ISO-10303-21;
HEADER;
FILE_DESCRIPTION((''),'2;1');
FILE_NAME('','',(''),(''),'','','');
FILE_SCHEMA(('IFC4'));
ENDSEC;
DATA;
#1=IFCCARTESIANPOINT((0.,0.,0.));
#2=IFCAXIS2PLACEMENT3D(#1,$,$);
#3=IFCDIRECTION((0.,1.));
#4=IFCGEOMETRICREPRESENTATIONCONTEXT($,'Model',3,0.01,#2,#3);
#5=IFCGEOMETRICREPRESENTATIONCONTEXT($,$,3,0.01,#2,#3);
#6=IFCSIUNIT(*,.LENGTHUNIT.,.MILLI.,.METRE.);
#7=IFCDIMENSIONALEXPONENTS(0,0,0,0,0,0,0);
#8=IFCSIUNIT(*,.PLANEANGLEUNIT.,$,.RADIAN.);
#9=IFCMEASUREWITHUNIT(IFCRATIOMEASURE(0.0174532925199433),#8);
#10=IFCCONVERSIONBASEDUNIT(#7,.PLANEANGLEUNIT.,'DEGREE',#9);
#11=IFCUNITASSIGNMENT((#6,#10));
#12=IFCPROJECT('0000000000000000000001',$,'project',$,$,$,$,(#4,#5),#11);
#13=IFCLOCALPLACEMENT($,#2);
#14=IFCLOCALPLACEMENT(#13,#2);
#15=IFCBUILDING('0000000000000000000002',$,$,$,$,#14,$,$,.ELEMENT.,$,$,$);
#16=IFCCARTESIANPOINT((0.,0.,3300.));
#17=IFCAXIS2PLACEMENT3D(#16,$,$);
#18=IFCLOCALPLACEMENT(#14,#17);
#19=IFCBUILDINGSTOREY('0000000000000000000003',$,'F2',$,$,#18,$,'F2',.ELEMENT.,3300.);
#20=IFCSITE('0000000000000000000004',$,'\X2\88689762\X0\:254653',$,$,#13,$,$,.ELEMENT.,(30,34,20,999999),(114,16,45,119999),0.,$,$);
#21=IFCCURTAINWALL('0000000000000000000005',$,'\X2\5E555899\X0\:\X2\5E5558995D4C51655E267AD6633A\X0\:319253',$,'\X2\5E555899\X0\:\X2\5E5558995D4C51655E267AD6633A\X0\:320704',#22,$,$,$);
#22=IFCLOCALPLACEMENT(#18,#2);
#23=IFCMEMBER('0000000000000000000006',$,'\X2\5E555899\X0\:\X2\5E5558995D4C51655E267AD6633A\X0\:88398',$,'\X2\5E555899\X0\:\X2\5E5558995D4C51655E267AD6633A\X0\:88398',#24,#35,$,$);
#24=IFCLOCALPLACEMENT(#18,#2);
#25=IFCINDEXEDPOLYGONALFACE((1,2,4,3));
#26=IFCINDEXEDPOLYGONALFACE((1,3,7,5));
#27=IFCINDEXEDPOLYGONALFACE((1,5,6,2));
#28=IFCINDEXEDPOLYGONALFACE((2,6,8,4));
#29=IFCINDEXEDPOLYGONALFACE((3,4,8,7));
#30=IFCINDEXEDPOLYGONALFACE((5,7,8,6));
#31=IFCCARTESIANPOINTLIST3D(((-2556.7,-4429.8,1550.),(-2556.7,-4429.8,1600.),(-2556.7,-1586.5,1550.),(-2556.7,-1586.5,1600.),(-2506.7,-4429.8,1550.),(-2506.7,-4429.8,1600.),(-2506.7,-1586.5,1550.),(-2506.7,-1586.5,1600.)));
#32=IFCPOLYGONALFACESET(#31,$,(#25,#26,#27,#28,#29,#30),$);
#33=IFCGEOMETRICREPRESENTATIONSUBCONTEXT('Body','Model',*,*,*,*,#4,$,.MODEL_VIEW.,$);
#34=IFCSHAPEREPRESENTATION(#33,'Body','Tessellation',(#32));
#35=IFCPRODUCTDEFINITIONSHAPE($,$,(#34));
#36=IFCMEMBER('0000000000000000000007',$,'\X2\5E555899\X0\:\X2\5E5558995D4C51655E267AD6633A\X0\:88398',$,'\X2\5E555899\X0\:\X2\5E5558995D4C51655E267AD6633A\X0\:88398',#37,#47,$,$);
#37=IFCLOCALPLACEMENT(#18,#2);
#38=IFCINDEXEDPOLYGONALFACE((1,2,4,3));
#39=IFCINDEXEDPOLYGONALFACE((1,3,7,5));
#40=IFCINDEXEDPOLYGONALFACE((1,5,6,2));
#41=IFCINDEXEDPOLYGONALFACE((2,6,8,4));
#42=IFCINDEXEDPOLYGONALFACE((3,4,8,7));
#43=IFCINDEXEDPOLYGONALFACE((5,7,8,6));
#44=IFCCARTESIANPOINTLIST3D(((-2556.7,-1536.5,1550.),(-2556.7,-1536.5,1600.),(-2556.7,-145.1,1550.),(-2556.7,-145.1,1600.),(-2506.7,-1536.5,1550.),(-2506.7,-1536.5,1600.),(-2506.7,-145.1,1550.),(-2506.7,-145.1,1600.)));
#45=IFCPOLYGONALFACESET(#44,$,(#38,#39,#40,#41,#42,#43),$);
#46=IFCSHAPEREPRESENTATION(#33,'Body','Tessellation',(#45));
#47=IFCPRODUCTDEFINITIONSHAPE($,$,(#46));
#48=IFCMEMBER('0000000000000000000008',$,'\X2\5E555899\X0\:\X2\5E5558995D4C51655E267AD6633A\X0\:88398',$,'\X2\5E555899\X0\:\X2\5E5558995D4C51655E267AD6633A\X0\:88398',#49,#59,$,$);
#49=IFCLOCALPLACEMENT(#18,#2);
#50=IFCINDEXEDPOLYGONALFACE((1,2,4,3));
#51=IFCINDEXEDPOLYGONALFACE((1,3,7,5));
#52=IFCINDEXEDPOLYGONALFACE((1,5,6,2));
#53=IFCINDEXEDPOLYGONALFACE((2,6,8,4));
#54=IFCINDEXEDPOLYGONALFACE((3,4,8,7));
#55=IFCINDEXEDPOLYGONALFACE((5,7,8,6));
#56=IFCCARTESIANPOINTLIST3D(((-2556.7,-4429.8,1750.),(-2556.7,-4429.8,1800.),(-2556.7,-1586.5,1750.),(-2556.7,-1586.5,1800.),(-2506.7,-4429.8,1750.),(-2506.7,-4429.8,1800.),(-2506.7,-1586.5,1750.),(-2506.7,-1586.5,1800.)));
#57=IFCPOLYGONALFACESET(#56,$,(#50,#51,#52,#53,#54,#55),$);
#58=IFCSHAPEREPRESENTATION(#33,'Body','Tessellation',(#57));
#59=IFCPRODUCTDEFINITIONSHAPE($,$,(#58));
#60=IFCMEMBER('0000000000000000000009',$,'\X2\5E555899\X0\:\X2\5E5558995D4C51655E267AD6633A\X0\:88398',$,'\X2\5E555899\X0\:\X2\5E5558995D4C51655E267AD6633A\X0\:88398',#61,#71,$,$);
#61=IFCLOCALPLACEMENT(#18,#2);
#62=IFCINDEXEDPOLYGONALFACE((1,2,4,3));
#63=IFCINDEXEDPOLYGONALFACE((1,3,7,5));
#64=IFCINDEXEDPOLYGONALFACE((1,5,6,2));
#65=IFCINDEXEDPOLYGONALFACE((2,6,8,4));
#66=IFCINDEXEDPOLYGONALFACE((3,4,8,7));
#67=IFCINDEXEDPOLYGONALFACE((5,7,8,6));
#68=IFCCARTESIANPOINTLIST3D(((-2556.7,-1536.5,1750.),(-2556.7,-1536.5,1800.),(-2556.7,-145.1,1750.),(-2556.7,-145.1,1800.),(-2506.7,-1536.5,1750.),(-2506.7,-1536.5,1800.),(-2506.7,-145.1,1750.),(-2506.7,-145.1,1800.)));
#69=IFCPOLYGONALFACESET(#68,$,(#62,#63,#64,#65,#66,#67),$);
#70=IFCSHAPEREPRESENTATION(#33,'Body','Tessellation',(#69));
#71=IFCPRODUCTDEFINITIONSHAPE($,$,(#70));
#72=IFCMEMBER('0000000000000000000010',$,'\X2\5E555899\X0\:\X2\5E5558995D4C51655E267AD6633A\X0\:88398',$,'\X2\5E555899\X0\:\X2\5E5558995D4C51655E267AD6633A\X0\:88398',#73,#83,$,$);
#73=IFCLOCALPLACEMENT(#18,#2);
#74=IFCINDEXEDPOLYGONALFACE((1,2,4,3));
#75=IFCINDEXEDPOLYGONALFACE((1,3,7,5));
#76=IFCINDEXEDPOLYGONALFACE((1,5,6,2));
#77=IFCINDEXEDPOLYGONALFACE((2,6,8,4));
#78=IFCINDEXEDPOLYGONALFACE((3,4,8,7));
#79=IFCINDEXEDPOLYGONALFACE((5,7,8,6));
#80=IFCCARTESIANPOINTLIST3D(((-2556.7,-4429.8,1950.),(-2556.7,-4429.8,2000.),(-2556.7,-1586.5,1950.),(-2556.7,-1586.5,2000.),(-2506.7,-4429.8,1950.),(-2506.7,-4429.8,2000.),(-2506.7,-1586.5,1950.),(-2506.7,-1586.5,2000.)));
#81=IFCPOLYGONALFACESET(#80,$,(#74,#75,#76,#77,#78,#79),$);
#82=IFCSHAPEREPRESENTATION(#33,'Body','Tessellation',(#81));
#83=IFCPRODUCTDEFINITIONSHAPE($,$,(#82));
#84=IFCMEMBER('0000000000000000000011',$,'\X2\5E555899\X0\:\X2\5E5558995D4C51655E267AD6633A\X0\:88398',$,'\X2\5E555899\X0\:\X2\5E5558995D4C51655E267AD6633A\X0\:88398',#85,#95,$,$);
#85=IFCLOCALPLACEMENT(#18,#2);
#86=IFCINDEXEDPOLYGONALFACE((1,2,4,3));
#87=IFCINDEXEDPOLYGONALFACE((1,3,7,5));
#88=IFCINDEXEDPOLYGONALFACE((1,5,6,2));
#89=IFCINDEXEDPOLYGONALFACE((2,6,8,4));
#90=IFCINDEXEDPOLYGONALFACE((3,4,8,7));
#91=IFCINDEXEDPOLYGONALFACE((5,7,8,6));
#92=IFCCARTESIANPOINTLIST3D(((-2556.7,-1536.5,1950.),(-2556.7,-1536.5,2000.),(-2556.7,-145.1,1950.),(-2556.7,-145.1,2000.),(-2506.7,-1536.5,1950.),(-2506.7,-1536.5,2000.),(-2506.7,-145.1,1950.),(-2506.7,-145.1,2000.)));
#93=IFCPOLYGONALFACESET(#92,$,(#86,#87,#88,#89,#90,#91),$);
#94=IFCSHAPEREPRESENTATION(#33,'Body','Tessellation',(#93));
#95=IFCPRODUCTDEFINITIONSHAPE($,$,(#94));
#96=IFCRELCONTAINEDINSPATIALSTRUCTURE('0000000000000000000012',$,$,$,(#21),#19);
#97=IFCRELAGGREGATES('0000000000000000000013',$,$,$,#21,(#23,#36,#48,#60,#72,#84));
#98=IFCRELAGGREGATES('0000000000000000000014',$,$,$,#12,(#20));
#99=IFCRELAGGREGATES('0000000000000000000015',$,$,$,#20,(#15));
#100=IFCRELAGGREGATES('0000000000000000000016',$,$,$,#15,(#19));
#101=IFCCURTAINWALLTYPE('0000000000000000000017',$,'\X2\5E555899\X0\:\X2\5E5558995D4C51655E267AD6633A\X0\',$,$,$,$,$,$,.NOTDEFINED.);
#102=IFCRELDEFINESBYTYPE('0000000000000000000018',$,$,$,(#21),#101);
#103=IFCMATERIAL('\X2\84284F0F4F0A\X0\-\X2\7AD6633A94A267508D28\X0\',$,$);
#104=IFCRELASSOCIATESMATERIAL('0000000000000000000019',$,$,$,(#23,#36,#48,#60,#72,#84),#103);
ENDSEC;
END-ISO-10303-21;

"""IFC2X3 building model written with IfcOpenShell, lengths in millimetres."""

from ifc_helpers import new_model, entity, si_unit, converted_unit, direction, frame, frame_2d, origin, origin_2d_with_axis, place, context, subcontext, project, spatial, rectangle, extrude, material, type_object, element, aggregate, save


model = new_model("IFC2X3")

# Units and contexts
model_context = context("Model", 3, precision=0.01, world=origin(), true_north=direction((0.0, 1.0)))
context_of_model = context(None, 3, precision=0.01, world=origin(), true_north=direction((0.0, 1.0)))
body_context = subcontext(model_context, "Body", "Model", "MODEL_VIEW")
ifc_project = project(units=[si_unit("LENGTHUNIT", "METRE", prefix="MILLI"), converted_unit("PLANEANGLEUNIT", "DEGREE", entity("IfcRatioMeasure", 0.0174532925199433), si_unit("PLANEANGLEUNIT", "RADIAN"), dimensions=[0, 0, 0, 0, 0, 0, 0])], contexts=[model_context, context_of_model])

# Site, building, storey
site_placement = place(None, origin())
site = spatial("IfcSite", under=ifc_project, at=site_placement, Name="表面:254653", CompositionType="ELEMENT", RefLatitude=(30, 34, 20, 999999), RefLongitude=(114, 16, 45, 119999), RefElevation=0.0)
building_placement = place(site_placement, origin())
building = spatial("IfcBuilding", under=site, at=building_placement, CompositionType="ELEMENT")
storey_placement = place(building_placement, frame((0.0, 0.0, 3300.0)))
storey = spatial("IfcBuildingStorey", under=building, at=storey_placement, Name="F2", LongName="F2", CompositionType="ELEMENT", Elevation=3300.0)

# Shared definitions
ifc_material_1 = material(Name="萨伏伊-竖挺钢材质")

# Curtain wall, members
curtain_wall_type_1 = type_object("IfcCurtainWallType", Name="幕墙:幕墙嵌入带竖挺", PredefinedType="NOTDEFINED")
curtain_wall_1_placement = place(storey_placement, frame((0.0, 0.0, -3300.0)))
curtain_wall_1 = element("IfcCurtainWall", 1, at=curtain_wall_1_placement, inside=storey, type_object=curtain_wall_type_1, Name="幕墙:幕墙嵌入带竖挺:319253", ObjectType="幕墙:幕墙嵌入带竖挺:320704")
member_1_placement = place(curtain_wall_1_placement, frame((0.0, 0.0, 3300.0)))
member_1 = element("IfcMember", 2, at=member_1_placement, material=ifc_material_1, Name="幕墙:幕墙嵌入带竖挺:88398", ObjectType="幕墙:幕墙嵌入带竖挺:88398", context=body_context, shape_type="SweptSolid", body=[
    extrude(rectangle(XDim=50.0, YDim=50.0, at=origin_2d_with_axis()), frame((-2531.7, -4429.8, 1575.0), z_axis=(0.0, 1.0, 0.0), x_axis=(0.0, 0.0, -1.0)), (0.0, 0.0, 1.0), 2843.3),
])
member_2_placement = place(curtain_wall_1_placement, frame((0.0, 0.0, 3300.0)))
member_2 = element("IfcMember", 3, at=member_2_placement, material=ifc_material_1, Name="幕墙:幕墙嵌入带竖挺:88398", ObjectType="幕墙:幕墙嵌入带竖挺:88398", context=body_context, shape_type="SweptSolid", body=[
    extrude(rectangle(XDim=50.0, YDim=50.0, at=frame_2d((0.0, 0.0), x_axis=(1.0, 0.0))), frame((-2531.7, -1536.5, 1575.0), z_axis=(0.0, 1.0, 0.0), x_axis=(0.0, 0.0, -1.0)), (0.0, 0.0, 1.0), 1391.3),
])
member_3_placement = place(curtain_wall_1_placement, frame((0.0, 0.0, 3300.0)))
member_3 = element("IfcMember", 4, at=member_3_placement, material=ifc_material_1, Name="幕墙:幕墙嵌入带竖挺:88398", ObjectType="幕墙:幕墙嵌入带竖挺:88398", context=body_context, shape_type="SweptSolid", body=[
    extrude(rectangle(XDim=50.0, YDim=50.0, at=origin_2d_with_axis()), frame((-2531.7, -4429.8, 1775.0), z_axis=(0.0, 1.0, 0.0), x_axis=(0.0, 0.0, -1.0)), (0.0, 0.0, 1.0), 2843.3),
])
member_4_placement = place(curtain_wall_1_placement, frame((0.0, 0.0, 3300.0)))
member_4 = element("IfcMember", 5, at=member_4_placement, material=ifc_material_1, Name="幕墙:幕墙嵌入带竖挺:88398", ObjectType="幕墙:幕墙嵌入带竖挺:88398", context=body_context, shape_type="SweptSolid", body=[
    extrude(rectangle(XDim=50.0, YDim=50.0, at=frame_2d((0.0, 0.0), x_axis=(1.0, 0.0))), frame((-2531.7, -1536.5, 1775.0), z_axis=(0.0, 1.0, 0.0), x_axis=(0.0, 0.0, -1.0)), (0.0, 0.0, 1.0), 1391.3),
])
member_5_placement = place(curtain_wall_1_placement, frame((0.0, 0.0, 3300.0)))
member_5 = element("IfcMember", 6, at=member_5_placement, material=ifc_material_1, Name="幕墙:幕墙嵌入带竖挺:88398", ObjectType="幕墙:幕墙嵌入带竖挺:88398", context=body_context, shape_type="SweptSolid", body=[
    extrude(rectangle(XDim=50.0, YDim=50.0, at=origin_2d_with_axis()), frame((-2531.7, -4429.8, 1975.0), z_axis=(0.0, 1.0, 0.0), x_axis=(0.0, 0.0, -1.0)), (0.0, 0.0, 1.0), 2843.3),
])
member_6_placement = place(curtain_wall_1_placement, frame((0.0, 0.0, 3300.0)))
member_6 = element("IfcMember", 7, at=member_6_placement, material=ifc_material_1, Name="幕墙:幕墙嵌入带竖挺:88398", ObjectType="幕墙:幕墙嵌入带竖挺:88398", context=body_context, shape_type="SweptSolid", body=[
    extrude(rectangle(XDim=50.0, YDim=50.0, at=frame_2d((0.0, 0.0), x_axis=(1.0, 0.0))), frame((-2531.7, -1536.5, 1975.0), z_axis=(0.0, 1.0, 0.0), x_axis=(0.0, 0.0, -1.0)), (0.0, 0.0, 1.0), 1391.3),
])
aggregate(curtain_wall_1, [member_1, member_2, member_3, member_4, member_5, member_6])

save(model, "model.ifc")
